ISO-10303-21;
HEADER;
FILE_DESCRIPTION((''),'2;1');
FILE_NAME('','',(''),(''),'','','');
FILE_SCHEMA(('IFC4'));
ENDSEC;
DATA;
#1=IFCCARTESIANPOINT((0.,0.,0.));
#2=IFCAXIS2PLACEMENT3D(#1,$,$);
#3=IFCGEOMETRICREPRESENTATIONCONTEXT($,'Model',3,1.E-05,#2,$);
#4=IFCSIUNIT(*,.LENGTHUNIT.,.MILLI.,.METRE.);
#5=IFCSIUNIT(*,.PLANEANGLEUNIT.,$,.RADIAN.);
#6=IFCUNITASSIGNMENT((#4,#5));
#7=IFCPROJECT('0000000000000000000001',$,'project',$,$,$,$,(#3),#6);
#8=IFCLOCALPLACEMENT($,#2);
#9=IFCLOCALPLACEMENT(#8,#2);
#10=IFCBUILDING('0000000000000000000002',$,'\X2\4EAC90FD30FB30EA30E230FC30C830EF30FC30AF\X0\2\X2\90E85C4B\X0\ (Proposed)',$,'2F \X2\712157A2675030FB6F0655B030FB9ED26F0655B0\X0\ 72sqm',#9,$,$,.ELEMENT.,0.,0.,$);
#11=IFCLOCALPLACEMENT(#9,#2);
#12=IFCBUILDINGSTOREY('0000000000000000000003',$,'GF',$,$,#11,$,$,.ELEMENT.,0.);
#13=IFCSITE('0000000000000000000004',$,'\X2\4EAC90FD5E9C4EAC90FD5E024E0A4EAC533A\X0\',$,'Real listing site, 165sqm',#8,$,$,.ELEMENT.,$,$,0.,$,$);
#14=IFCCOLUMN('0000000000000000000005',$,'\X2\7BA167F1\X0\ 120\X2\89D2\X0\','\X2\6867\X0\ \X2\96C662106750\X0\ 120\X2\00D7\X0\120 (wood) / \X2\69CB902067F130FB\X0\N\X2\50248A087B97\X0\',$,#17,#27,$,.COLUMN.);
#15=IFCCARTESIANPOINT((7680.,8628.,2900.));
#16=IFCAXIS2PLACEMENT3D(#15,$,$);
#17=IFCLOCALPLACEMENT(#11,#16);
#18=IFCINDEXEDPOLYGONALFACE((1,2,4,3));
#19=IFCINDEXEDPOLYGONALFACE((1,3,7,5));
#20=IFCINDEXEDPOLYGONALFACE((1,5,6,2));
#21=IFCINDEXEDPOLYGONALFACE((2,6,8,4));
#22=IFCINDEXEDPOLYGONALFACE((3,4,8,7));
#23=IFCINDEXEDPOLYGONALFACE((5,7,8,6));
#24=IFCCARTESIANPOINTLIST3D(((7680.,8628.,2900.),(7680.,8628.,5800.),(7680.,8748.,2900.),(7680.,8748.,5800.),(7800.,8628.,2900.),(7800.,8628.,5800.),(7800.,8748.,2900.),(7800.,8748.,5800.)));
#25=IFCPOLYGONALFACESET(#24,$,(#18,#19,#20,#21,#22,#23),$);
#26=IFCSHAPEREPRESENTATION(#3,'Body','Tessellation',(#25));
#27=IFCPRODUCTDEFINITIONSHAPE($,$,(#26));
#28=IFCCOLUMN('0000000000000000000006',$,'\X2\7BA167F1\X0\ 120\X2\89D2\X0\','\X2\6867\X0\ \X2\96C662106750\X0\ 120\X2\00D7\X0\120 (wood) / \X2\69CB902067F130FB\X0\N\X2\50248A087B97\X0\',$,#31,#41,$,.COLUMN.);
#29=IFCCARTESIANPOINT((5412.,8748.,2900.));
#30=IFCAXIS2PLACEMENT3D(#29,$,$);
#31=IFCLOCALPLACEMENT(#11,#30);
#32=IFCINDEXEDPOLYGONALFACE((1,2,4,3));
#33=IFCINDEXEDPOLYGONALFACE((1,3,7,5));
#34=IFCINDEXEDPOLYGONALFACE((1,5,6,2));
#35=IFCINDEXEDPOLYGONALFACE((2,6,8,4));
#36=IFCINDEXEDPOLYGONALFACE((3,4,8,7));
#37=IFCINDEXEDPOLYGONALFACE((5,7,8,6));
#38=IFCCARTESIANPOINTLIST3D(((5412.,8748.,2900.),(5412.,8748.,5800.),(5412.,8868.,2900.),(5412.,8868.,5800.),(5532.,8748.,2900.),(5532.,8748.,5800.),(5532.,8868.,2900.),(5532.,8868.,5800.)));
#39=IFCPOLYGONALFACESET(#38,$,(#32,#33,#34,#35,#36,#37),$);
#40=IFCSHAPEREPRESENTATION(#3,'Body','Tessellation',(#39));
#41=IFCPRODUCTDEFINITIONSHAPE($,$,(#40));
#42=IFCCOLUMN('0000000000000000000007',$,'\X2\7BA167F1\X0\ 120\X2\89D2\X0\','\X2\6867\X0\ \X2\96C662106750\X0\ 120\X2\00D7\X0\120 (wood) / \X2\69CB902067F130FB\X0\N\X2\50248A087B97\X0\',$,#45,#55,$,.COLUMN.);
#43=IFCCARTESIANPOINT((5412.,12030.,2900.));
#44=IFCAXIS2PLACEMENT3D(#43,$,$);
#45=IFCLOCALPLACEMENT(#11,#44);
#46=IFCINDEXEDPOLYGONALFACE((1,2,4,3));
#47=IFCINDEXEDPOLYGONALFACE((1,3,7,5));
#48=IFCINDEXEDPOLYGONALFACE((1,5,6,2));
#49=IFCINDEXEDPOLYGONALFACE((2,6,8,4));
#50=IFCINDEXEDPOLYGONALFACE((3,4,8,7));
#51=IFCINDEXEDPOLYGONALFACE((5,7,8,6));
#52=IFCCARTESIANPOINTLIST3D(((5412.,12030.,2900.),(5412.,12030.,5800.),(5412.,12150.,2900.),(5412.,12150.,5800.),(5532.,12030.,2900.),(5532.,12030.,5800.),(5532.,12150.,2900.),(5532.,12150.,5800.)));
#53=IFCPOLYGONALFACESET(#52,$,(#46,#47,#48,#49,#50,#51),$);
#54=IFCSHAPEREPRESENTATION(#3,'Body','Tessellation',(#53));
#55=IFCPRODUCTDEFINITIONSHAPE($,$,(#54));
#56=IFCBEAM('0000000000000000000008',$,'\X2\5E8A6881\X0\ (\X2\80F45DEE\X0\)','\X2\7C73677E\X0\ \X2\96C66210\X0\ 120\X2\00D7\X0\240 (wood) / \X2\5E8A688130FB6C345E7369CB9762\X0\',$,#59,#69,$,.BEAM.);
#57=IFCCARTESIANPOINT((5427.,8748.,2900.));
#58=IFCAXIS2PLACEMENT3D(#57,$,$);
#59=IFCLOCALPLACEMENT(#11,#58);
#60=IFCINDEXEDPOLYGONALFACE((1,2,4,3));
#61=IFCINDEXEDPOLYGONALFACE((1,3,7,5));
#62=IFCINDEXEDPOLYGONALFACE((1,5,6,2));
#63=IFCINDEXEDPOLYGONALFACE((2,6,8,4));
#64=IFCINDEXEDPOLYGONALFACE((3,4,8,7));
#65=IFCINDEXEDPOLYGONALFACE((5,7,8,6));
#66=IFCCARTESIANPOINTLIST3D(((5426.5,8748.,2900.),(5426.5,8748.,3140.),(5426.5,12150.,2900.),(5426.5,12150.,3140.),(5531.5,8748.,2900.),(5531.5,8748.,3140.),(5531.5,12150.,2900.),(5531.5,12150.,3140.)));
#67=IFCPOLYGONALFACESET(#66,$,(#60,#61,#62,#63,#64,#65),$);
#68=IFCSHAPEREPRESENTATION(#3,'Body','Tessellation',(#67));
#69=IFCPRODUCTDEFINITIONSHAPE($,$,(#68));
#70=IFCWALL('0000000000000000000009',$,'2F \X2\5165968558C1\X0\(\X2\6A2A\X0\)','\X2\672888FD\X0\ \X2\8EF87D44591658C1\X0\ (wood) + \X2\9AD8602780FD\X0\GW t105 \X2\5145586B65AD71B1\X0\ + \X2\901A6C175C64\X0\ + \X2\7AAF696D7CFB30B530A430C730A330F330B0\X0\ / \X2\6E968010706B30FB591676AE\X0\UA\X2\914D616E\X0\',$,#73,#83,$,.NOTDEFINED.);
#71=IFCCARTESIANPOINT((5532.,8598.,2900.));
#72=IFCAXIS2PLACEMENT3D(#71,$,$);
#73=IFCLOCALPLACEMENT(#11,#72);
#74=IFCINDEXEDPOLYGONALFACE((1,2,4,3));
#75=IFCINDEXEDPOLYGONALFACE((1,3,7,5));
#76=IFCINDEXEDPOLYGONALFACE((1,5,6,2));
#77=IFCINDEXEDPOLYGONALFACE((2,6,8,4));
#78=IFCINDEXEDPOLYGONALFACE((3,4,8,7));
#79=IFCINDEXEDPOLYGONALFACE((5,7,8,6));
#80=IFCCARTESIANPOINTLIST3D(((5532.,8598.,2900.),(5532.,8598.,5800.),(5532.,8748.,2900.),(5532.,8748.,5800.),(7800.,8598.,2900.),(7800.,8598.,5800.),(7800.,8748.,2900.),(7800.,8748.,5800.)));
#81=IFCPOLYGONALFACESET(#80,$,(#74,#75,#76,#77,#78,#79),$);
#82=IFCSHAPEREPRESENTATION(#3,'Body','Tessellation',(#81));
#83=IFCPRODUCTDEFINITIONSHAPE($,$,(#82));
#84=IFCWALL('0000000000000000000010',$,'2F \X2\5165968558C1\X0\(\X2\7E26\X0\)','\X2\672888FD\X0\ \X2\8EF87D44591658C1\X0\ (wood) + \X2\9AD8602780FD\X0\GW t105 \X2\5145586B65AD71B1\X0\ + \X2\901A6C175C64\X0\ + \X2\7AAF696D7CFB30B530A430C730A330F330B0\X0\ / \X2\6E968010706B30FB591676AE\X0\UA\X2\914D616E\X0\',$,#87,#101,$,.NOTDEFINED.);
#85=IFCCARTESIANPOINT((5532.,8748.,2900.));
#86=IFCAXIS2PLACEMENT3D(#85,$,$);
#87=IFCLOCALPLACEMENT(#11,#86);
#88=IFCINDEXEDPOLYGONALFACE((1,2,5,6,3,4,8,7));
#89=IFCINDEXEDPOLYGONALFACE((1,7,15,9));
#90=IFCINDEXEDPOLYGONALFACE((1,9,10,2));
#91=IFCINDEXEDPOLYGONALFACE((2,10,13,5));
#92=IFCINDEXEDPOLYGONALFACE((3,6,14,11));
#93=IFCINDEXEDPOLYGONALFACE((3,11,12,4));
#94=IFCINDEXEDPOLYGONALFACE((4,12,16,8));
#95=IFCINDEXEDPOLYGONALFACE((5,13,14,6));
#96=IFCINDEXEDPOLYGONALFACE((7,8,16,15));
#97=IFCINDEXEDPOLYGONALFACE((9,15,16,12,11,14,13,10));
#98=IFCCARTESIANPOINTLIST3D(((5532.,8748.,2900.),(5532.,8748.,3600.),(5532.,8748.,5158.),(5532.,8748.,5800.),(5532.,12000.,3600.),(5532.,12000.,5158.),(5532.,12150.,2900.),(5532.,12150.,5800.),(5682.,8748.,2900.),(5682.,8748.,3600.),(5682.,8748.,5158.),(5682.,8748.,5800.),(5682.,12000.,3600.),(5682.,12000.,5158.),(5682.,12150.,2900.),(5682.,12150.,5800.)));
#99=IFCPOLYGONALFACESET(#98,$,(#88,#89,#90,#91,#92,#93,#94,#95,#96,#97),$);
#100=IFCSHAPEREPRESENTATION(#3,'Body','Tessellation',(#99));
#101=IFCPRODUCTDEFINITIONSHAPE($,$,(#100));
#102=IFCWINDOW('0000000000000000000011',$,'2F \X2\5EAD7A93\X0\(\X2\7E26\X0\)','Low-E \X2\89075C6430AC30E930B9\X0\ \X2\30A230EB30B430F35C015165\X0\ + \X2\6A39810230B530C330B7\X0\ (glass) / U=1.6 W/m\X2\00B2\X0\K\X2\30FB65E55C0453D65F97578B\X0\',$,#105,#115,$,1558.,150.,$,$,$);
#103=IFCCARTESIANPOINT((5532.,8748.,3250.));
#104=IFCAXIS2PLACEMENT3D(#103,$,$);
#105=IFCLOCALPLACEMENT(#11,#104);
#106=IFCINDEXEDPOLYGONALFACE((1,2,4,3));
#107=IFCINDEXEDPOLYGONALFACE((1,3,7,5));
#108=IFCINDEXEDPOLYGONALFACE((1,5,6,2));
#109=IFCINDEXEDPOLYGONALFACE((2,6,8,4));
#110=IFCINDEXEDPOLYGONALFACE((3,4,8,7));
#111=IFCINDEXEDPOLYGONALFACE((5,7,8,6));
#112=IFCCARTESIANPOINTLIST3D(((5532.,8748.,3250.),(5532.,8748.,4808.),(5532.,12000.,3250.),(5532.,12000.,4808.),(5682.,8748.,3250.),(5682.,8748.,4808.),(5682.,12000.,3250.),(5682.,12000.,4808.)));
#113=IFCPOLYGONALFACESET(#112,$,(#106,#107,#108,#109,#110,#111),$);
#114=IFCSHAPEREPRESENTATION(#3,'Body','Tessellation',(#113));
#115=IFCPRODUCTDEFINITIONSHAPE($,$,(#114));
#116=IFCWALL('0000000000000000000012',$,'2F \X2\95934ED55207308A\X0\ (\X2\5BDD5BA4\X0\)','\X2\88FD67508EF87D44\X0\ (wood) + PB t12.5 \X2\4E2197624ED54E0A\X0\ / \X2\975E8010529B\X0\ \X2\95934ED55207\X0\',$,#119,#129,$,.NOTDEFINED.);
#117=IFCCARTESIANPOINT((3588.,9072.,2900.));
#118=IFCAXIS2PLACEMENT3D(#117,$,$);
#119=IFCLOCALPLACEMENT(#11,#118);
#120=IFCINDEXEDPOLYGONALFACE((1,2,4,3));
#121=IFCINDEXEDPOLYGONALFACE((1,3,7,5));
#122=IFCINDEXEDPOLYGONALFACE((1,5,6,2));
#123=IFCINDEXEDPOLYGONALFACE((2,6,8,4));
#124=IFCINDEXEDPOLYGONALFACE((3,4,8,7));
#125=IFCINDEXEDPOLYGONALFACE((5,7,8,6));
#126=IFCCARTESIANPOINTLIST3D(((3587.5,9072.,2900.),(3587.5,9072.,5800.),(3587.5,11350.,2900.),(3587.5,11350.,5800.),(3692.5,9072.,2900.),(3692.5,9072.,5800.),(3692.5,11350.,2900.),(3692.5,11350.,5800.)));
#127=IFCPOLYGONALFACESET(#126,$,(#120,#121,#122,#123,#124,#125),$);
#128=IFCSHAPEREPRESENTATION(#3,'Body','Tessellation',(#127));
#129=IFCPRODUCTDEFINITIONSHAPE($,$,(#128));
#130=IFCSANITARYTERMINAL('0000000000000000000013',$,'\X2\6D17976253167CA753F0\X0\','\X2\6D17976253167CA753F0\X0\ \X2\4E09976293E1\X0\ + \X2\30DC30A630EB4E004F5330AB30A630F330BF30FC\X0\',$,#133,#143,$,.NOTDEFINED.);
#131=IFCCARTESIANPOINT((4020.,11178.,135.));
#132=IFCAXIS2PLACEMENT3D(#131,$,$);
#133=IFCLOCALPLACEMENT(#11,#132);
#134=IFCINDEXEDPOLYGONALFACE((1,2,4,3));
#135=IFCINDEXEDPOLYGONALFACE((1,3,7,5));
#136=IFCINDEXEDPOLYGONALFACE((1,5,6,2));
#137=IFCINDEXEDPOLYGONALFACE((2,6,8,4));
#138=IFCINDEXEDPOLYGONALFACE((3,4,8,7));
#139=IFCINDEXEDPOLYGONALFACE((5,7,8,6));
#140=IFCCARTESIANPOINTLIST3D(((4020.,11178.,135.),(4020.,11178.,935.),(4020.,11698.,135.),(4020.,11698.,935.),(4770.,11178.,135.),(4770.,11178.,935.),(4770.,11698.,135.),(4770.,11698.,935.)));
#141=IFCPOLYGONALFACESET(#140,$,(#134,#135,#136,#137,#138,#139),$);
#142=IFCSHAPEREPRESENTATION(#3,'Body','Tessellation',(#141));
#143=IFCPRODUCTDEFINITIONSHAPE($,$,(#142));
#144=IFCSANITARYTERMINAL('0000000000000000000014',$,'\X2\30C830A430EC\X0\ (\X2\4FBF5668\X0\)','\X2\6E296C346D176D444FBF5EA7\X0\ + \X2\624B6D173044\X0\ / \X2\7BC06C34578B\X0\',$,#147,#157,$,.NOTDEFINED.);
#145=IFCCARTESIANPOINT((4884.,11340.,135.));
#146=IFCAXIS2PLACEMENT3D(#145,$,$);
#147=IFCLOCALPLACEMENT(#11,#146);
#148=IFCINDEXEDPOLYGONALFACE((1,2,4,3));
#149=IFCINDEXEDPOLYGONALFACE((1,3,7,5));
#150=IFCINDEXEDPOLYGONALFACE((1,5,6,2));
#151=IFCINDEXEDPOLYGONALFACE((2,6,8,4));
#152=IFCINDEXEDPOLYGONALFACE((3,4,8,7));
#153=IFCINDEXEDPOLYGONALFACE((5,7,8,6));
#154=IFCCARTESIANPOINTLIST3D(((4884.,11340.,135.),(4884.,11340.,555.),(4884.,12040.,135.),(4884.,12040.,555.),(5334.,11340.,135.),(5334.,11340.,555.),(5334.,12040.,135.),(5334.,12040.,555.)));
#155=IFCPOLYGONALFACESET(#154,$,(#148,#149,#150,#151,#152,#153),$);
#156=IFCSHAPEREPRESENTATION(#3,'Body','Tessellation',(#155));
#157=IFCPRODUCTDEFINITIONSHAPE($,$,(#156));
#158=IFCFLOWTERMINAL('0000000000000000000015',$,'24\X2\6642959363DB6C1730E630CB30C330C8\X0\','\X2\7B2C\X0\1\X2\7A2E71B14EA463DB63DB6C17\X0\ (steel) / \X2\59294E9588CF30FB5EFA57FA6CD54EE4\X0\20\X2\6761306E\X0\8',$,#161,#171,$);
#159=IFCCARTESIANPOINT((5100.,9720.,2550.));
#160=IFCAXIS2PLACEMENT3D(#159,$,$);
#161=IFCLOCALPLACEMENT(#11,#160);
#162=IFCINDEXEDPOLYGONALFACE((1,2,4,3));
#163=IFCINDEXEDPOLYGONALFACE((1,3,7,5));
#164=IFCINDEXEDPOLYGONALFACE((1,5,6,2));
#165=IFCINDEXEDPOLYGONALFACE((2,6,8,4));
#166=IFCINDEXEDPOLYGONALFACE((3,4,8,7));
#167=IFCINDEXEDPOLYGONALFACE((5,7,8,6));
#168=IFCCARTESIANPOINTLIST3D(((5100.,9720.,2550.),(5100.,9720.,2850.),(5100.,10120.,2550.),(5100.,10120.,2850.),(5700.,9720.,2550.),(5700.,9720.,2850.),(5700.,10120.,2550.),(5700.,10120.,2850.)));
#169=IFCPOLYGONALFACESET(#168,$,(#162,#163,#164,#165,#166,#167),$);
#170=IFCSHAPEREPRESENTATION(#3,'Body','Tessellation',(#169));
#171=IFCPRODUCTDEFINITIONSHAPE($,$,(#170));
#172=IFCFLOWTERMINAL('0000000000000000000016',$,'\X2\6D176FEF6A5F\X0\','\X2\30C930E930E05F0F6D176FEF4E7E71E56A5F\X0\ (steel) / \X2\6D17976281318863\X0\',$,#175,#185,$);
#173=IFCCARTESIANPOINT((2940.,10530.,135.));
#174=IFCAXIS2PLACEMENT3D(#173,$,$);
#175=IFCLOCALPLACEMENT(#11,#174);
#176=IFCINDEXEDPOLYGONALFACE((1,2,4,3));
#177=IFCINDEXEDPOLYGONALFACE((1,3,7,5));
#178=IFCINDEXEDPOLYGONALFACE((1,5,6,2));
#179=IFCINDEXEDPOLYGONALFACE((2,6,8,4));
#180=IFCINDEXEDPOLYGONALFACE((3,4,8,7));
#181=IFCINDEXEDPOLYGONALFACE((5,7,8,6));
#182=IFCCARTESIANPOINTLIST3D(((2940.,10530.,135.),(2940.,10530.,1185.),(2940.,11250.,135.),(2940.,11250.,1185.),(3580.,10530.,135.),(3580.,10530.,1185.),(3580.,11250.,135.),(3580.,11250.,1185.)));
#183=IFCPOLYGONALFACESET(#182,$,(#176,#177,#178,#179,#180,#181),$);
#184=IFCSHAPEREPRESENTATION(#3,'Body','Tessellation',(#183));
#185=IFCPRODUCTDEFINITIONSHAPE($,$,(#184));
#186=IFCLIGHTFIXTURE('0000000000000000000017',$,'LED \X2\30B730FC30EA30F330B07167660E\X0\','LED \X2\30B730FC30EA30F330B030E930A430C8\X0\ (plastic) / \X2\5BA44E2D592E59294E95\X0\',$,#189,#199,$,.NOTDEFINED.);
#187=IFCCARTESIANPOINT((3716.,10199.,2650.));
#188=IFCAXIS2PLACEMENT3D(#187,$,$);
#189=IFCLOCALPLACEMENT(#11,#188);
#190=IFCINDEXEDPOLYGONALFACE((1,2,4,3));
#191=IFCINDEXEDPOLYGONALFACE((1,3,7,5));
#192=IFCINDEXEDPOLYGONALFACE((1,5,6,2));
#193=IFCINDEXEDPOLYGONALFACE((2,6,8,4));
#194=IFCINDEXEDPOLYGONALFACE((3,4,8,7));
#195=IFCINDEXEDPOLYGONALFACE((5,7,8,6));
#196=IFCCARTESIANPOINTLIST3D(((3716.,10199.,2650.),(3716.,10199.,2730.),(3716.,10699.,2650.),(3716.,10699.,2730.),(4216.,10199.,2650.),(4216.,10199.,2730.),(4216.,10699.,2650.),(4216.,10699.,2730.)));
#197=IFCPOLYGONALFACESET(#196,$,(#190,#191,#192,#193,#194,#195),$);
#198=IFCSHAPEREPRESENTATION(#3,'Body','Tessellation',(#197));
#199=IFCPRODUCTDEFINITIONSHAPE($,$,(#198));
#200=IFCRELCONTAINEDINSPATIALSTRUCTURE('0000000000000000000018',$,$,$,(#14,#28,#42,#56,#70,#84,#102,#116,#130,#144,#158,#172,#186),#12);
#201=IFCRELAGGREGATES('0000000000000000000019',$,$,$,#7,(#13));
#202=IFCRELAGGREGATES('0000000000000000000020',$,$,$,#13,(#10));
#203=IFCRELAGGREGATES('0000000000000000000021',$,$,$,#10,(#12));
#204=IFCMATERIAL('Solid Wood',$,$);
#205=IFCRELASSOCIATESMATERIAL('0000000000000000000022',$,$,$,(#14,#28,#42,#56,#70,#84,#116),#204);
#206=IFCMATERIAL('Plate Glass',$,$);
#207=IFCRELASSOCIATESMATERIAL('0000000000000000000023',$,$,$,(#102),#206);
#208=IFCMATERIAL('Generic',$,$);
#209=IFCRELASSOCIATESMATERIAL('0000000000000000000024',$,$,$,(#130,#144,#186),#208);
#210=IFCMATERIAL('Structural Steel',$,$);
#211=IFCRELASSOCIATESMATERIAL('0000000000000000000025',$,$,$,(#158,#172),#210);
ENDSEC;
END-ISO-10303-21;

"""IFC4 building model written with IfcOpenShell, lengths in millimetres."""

from ifc_helpers import new_model, si_unit, frame, frame_2d, origin, place, context, project, spatial, rectangle, extrude, material, element, fill, save


model = new_model("IFC4")

# Units and contexts
model_context = context("Model", 3, precision=1e-05, world=origin())
ifc_project = project(units=[si_unit("LENGTHUNIT", "METRE", prefix="MILLI"), si_unit("PLANEANGLEUNIT", "RADIAN")], contexts=[model_context])

# Site, building, storey
site_placement = place(None, origin())
site = spatial("IfcSite", under=ifc_project, at=site_placement, Name="京都府京都市上京区", ObjectType="Real listing site, 165sqm", CompositionType="ELEMENT", RefElevation=0.0)
building_placement = place(site_placement, origin())
building = spatial("IfcBuilding", under=site, at=building_placement, Name="京都・リモートワーク2部屋 (Proposed)", ObjectType="2F 無垢材・漆喰・黒漆喰 72sqm", CompositionType="ELEMENT", ElevationOfRefHeight=0.0, ElevationOfTerrain=0.0)
storey_placement = place(building_placement, origin())
storey = spatial("IfcBuildingStorey", under=building, at=storey_placement, Name="GF", CompositionType="ELEMENT", Elevation=0.0)

# Columns
ifc_material_1 = material(Name="Solid Wood")
column_1_placement = place(storey_placement, frame((7680.0, 8628.0, 2900.0)))
element("IfcColumn", 1, at=column_1_placement, inside=storey, material=ifc_material_1, Name="管柱 120角", Description="桧 集成材 120×120 (wood) / 構造柱・N値計算", PredefinedType="COLUMN", context=model_context, shape_type="SweptSolid", body=[
    extrude(rectangle(XDim=120.0, YDim=120.0, at=frame_2d((60.0, 60.0))), frame((7680.0, 8628.0, 2900.0)), (0.0, 0.0, 1.0), 2900.0),
])
column_2_placement = place(storey_placement, frame((5412.0, 8748.0, 2900.0)))
element("IfcColumn", 2, at=column_2_placement, inside=storey, material=ifc_material_1, Name="管柱 120角", Description="桧 集成材 120×120 (wood) / 構造柱・N値計算", PredefinedType="COLUMN", context=model_context, shape_type="SweptSolid", body=[
    extrude(rectangle(XDim=120.0, YDim=120.0, at=frame_2d((60.0, 60.0))), frame((5412.0, 8748.0, 2900.0)), (0.0, 0.0, 1.0), 2900.0),
])
column_3_placement = place(storey_placement, frame((5412.0, 12030.0, 2900.0)))
element("IfcColumn", 3, at=column_3_placement, inside=storey, material=ifc_material_1, Name="管柱 120角", Description="桧 集成材 120×120 (wood) / 構造柱・N値計算", PredefinedType="COLUMN", context=model_context, shape_type="SweptSolid", body=[
    extrude(rectangle(XDim=120.0, YDim=120.0, at=frame_2d((60.0, 60.0))), frame((5412.0, 12030.0, 2900.0)), (0.0, 0.0, 1.0), 2900.0),
])

# Beam
beam_placement = place(storey_placement, frame((5427.0, 8748.0, 2900.0)))
element("IfcBeam", 4, at=beam_placement, inside=storey, material=ifc_material_1, Name="床梁 (胴差)", Description="米松 集成 120×240 (wood) / 床梁・水平構面", PredefinedType="BEAM", context=model_context, shape_type="SweptSolid", body=[
    extrude(rectangle(XDim=105.0, YDim=3402.0, at=frame_2d((52.0, 1701.0))), frame((5427.0, 8748.0, 2900.0)), (0.0, 0.0, 1.0), 240.0),
])

# Wall
wall_1_placement = place(storey_placement, frame((5532.0, 8598.0, 2900.0)))
element("IfcWall", 5, at=wall_1_placement, inside=storey, material=ifc_material_1, Name="2F 入隅壁(横)", Description="木製 軸組外壁 (wood) + 高性能GW t105 充填断熱 + 通気層 + 窯業系サイディング / 準耐火・外皮UA配慮", PredefinedType="NOTDEFINED", context=model_context, shape_type="SweptSolid", body=[
    extrude(rectangle(XDim=2268.0, YDim=150.0, at=frame_2d((1134.0, 75.0))), frame((5532.0, 8598.0, 2900.0)), (0.0, 0.0, 1.0), 2900.0),
])

# Wall, opening, window
wall_2_placement = place(storey_placement, frame((5532.0, 8748.0, 2900.0)))
wall_2 = element("IfcWall", 6, at=wall_2_placement, inside=storey, material=ifc_material_1, Name="2F 入隅壁(縦)", Description="木製 軸組外壁 (wood) + 高性能GW t105 充填断熱 + 通気層 + 窯業系サイディング / 準耐火・外皮UA配慮", PredefinedType="NOTDEFINED", context=model_context, shape_type="SweptSolid", body=[
    extrude(rectangle(XDim=150.0, YDim=3402.0, at=frame_2d((75.0, 1701.0))), frame((5532.0, 8748.0, 2900.0)), (0.0, 0.0, 1.0), 2900.0),
])
opening_placement = place(storey_placement, frame((5532.0, 8748.0, 3250.0)))
opening = element("IfcOpeningElement", 7, at=opening_placement, cuts=wall_2, PredefinedType="NOTDEFINED", context=model_context, shape_type="SweptSolid", body=[
    extrude(rectangle(XDim=150.0, YDim=3252.0, at=frame_2d((75.0, 1626.0))), frame((5532.0, 8748.0, 3250.0)), (0.0, 0.0, 1.0), 1558.0),
])
ifc_material_2 = material(Name="Plate Glass")
window_placement = place(storey_placement, frame((5532.0, 8748.0, 3250.0)))
window = element("IfcWindow", 8, at=window_placement, inside=storey, material=ifc_material_2, Name="2F 庭窓(縦)", Description="Low-E 複層ガラス アルゴン封入 + 樹脂サッシ (glass) / U=1.6 W/m²K・日射取得型", OverallHeight=1558.0, OverallWidth=150.0, context=model_context, shape_type="SweptSolid", body=[
    extrude(rectangle(XDim=150.0, YDim=3252.0, at=frame_2d((75.0, 1626.0))), frame((5532.0, 8748.0, 3250.0)), (0.0, 0.0, 1.0), 1558.0),
])
fill(opening, window)

# Wall
wall_3_placement = place(storey_placement, frame((3588.0, 9072.0, 2900.0)))
element("IfcWall", 9, at=wall_3_placement, inside=storey, material=ifc_material_1, Name="2F 間仕切り (寝室)", Description="製材軸組 (wood) + PB t12.5 両面仕上 / 非耐力 間仕切", PredefinedType="NOTDEFINED", context=model_context, shape_type="SweptSolid", body=[
    extrude(rectangle(XDim=105.0, YDim=2278.0, at=frame_2d((52.0, 1139.0))), frame((3588.0, 9072.0, 2900.0)), (0.0, 0.0, 1.0), 2900.0),
])

# Sanitary terminals
ifc_material_3 = material(Name="Generic")
sanitary_terminal_1_placement = place(storey_placement, frame((4020.0, 11178.0, 135.0)))
element("IfcSanitaryTerminal", 10, at=sanitary_terminal_1_placement, inside=storey, material=ifc_material_3, Name="洗面化粧台", Description="洗面化粧台 三面鏡 + ボウル一体カウンター", PredefinedType="NOTDEFINED", context=model_context, shape_type="SweptSolid", body=[
    extrude(rectangle(XDim=750.0, YDim=520.0, at=frame_2d((375.0, 260.0))), frame((4020.0, 11178.0, 135.0)), (0.0, 0.0, 1.0), 800.0),
])
sanitary_terminal_2_placement = place(storey_placement, frame((4884.0, 11340.0, 135.0)))
element("IfcSanitaryTerminal", 11, at=sanitary_terminal_2_placement, inside=storey, material=ifc_material_3, Name="トイレ (便器)", Description="温水洗浄便座 + 手洗い / 節水型", PredefinedType="NOTDEFINED", context=model_context, shape_type="SweptSolid", body=[
    extrude(rectangle(XDim=450.0, YDim=700.0, at=frame_2d((225.0, 350.0))), frame((4884.0, 11340.0, 135.0)), (0.0, 0.0, 1.0), 420.0),
])

# Flow terminals
ifc_material_4 = material(Name="Structural Steel")
flow_terminal_1_placement = place(storey_placement, frame((5100.0, 9720.0, 2550.0)))
element("IfcFlowTerminal", 12, at=flow_terminal_1_placement, inside=storey, material=ifc_material_4, Name="24時間換気ユニット", Description="第1種熱交換換気 (steel) / 天井裏・建基法令20条の8", context=model_context, shape_type="SweptSolid", body=[
    extrude(rectangle(XDim=600.0, YDim=400.0, at=frame_2d((300.0, 200.0))), frame((5100.0, 9720.0, 2550.0)), (0.0, 0.0, 1.0), 300.0),
])
flow_terminal_2_placement = place(storey_placement, frame((2940.0, 10530.0, 135.0)))
element("IfcFlowTerminal", 13, at=flow_terminal_2_placement, inside=storey, material=ifc_material_4, Name="洗濯機", Description="ドラム式洗濯乾燥機 (steel) / 洗面脱衣", context=model_context, shape_type="SweptSolid", body=[
    extrude(rectangle(XDim=640.0, YDim=720.0, at=frame_2d((320.0, 360.0))), frame((2940.0, 10530.0, 135.0)), (0.0, 0.0, 1.0), 1050.0),
])

# Light fixture
light_fixture_1_placement = place(storey_placement, frame((3716.0, 10199.0, 2650.0)))
element("IfcLightFixture", 14, at=light_fixture_1_placement, inside=storey, material=ifc_material_3, Name="LED シーリング照明", Description="LED シーリングライト (plastic) / 室中央天井", PredefinedType="NOTDEFINED", context=model_context, shape_type="SweptSolid", body=[
    extrude(rectangle(XDim=500.0, YDim=500.0, at=frame_2d((250.0, 250.0))), frame((3716.0, 10199.0, 2650.0)), (0.0, 0.0, 1.0), 80.0),
])

save(model, "model.ifc")
